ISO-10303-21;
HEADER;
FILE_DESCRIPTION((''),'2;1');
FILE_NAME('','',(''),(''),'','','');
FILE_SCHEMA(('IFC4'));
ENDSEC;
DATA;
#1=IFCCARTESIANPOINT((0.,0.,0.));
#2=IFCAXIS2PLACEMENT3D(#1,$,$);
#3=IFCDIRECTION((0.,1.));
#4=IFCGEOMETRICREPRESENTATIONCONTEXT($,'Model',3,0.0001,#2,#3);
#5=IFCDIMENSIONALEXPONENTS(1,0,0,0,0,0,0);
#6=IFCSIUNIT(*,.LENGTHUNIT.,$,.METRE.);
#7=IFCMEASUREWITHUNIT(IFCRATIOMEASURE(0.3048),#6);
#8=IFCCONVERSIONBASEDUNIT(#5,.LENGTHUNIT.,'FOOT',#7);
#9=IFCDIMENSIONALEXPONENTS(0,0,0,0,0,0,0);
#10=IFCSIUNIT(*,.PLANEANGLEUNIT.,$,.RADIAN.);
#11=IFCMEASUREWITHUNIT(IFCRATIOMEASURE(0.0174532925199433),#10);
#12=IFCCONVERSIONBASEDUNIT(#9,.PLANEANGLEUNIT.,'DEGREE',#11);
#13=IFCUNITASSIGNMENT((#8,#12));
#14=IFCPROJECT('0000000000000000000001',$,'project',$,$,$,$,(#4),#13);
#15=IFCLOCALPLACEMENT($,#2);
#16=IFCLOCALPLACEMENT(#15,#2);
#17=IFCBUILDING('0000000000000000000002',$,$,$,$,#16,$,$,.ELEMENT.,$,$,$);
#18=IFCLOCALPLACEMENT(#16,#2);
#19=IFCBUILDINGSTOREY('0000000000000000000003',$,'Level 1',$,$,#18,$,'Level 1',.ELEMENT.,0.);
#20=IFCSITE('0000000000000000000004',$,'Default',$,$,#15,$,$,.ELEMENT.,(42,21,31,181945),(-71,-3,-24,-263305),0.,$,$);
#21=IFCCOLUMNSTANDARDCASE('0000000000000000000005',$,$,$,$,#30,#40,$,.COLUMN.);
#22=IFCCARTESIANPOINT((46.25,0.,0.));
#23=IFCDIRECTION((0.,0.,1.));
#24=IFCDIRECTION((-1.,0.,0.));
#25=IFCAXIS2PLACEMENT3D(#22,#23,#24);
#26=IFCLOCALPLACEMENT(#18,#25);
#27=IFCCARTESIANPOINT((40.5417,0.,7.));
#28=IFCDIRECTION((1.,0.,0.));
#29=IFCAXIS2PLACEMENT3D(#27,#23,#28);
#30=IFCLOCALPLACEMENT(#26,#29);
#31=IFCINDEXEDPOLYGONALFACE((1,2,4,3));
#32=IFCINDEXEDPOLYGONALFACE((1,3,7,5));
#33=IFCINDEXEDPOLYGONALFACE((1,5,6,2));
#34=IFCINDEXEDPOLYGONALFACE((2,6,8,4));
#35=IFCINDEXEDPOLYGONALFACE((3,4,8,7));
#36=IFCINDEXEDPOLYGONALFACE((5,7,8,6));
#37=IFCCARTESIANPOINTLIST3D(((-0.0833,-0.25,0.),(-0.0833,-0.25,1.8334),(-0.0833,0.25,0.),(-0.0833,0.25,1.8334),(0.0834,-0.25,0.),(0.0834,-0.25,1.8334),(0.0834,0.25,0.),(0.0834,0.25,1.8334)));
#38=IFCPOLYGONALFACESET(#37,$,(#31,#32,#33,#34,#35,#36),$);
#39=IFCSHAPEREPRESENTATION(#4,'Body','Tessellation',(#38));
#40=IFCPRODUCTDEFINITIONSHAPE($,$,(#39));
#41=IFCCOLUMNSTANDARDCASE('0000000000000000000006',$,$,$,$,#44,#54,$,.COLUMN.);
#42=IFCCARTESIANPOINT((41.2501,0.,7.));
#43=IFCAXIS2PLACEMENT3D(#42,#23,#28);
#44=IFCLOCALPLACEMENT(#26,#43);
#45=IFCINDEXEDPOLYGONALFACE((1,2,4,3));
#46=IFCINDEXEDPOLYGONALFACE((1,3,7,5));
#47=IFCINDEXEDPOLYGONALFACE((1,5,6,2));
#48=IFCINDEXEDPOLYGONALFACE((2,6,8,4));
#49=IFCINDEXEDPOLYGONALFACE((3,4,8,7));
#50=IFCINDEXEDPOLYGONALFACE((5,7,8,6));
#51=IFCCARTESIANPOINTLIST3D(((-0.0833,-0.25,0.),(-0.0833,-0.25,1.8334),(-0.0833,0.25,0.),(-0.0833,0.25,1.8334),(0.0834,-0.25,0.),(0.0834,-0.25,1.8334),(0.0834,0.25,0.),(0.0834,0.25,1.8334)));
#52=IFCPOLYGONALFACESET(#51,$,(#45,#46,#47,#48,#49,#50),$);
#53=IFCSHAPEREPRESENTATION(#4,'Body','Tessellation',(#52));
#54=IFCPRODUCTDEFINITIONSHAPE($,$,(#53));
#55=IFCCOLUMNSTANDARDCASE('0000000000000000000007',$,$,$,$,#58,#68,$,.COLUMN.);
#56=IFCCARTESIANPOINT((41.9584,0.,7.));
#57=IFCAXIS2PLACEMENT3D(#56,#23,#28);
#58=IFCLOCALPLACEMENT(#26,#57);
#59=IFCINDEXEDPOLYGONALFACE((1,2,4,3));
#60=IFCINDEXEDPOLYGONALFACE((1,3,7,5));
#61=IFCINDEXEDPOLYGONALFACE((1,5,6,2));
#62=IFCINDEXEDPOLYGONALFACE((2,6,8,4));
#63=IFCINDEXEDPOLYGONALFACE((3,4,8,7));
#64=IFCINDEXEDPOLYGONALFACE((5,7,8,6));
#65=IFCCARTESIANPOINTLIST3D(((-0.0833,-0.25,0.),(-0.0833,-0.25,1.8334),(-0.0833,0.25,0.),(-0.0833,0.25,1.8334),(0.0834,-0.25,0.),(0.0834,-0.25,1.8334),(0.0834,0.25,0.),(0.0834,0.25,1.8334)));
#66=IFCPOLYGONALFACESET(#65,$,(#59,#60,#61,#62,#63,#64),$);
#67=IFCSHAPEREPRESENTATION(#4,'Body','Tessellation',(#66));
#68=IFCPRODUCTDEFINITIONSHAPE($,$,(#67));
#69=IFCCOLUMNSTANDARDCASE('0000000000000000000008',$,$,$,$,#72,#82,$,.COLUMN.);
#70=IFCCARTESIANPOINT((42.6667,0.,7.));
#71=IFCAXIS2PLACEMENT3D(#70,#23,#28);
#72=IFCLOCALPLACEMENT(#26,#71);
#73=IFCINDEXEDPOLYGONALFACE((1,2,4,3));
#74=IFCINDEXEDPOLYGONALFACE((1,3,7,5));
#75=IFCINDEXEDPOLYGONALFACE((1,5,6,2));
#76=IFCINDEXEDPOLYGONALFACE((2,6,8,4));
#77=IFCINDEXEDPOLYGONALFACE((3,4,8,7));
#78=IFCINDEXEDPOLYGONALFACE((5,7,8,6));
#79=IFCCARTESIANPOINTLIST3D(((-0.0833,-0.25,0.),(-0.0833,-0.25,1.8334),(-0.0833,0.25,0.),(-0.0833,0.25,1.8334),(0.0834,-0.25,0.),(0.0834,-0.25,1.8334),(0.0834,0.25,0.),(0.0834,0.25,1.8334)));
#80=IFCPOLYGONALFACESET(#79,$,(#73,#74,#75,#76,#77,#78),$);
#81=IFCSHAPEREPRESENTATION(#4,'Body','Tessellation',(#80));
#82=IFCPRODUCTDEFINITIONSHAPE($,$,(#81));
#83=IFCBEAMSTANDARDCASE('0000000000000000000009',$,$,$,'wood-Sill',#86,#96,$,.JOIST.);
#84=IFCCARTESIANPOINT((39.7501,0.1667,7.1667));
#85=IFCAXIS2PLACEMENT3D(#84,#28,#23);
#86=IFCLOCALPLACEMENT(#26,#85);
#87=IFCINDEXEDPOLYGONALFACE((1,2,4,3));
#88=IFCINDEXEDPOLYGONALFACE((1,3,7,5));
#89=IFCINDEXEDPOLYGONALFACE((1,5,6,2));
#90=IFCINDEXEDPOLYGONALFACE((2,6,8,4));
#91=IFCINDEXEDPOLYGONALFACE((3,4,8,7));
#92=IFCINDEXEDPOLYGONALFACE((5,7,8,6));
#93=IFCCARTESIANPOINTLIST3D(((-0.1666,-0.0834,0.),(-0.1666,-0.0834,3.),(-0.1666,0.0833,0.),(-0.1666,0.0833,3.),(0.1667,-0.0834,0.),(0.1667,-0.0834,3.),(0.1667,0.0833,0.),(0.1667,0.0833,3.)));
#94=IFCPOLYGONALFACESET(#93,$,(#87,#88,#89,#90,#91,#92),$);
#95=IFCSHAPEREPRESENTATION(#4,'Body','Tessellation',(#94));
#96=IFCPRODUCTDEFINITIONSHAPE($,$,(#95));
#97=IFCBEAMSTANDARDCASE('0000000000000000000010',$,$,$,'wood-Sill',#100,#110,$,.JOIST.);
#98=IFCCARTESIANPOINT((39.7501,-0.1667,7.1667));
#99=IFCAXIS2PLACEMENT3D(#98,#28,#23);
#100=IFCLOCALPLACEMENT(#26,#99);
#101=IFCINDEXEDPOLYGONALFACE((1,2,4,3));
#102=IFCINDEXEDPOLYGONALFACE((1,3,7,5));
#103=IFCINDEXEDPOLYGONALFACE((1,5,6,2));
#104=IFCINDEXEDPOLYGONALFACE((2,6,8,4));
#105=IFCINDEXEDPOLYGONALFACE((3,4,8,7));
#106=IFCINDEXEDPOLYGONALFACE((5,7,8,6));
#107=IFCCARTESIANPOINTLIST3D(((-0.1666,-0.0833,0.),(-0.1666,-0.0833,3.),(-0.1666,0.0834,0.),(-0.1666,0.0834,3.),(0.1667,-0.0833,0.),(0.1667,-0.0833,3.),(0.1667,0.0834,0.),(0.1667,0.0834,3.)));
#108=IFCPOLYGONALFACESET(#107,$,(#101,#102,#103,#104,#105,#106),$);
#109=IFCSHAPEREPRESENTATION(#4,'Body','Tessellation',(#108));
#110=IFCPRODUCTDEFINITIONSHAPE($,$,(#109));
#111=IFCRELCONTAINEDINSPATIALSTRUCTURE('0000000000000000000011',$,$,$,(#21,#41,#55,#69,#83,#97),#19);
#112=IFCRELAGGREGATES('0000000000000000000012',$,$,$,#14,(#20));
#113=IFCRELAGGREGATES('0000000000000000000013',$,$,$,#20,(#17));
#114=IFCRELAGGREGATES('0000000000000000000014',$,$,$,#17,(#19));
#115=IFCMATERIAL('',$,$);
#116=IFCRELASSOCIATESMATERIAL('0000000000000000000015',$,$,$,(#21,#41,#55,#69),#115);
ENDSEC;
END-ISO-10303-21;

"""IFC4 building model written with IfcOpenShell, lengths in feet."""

from ifc_helpers import new_model, entity, si_unit, converted_unit, direction, frame, origin, origin_with_axes, place, context, project, spatial, rectangle, extrude, material, element, save


model = new_model("IFC4")

# Units and contexts
model_context = context("Model", 3, precision=0.0001, world=origin(), true_north=direction((0.0, 1.0)))
ifc_project = project(units=[converted_unit("LENGTHUNIT", "FOOT", entity("IfcRatioMeasure", 0.3048), si_unit("LENGTHUNIT", "METRE"), dimensions=[1, 0, 0, 0, 0, 0, 0]), converted_unit("PLANEANGLEUNIT", "DEGREE", entity("IfcRatioMeasure", 0.0174532925199433), si_unit("PLANEANGLEUNIT", "RADIAN"), dimensions=[0, 0, 0, 0, 0, 0, 0])], contexts=[model_context])

# Site, building, storey
site_placement = place(None, origin())
site = spatial("IfcSite", under=ifc_project, at=site_placement, Name="Default", CompositionType="ELEMENT", RefLatitude=(42, 21, 31, 181945), RefLongitude=(-71, -3, -24, -263305), RefElevation=0.0)
building_placement = place(site_placement, origin())
building = spatial("IfcBuilding", under=site, at=building_placement, CompositionType="ELEMENT")
storey_placement = place(building_placement, origin())
storey = spatial("IfcBuildingStorey", under=building, at=storey_placement, Name="Level 1", LongName="Level 1", CompositionType="ELEMENT", Elevation=0.0)

# Columns
placement_1 = place(storey_placement, frame((46.25, 0.0, 0.0), z_axis=(0.0, 0.0, 1.0), x_axis=(-1.0, 0.0, 0.0)))
ifc_material_1 = material(Name="")
for number, where, z_axis, x_axis in (
    (1, (40.5417, 0.0, 7.0), (0.0, 0.0, 1.0), (1.0, 0.0, 0.0)),
    (2, (41.2501, 0.0, 7.0), (0.0, 0.0, 1.0), (1.0, 0.0, 0.0)),
    (3, (41.9584, 0.0, 7.0), (0.0, 0.0, 1.0), (1.0, 0.0, 0.0)),
    (4, (42.6667, 0.0, 7.0), (0.0, 0.0, 1.0), (1.0, 0.0, 0.0)),
):
    element("IfcColumnStandardCase", number, at=place(placement_1, frame(where, z_axis=z_axis, x_axis=x_axis)), inside=storey, material=ifc_material_1, PredefinedType="COLUMN", context=model_context, shape_type="SweptSolid", body=[
        extrude(rectangle(XDim=0.1667, YDim=0.5), origin(), (0.0, 0.0, 1.0), 1.8334),
    ])

# Beams
for number, where, z_axis, x_axis in (
    (5, (39.7501, 0.1667, 7.1667), (1.0, 0.0, 0.0), (0.0, 0.0, 1.0)),
    (6, (39.7501, -0.1667, 7.1667), (1.0, 0.0, 0.0), (0.0, 0.0, 1.0)),
):
    element("IfcBeamStandardCase", number, at=place(placement_1, frame(where, z_axis=z_axis, x_axis=x_axis)), inside=storey, ObjectType="wood-Sill", PredefinedType="JOIST", context=model_context, shape_type="SweptSolid", body=[
        extrude(rectangle(XDim=0.3333, YDim=0.1667), origin_with_axes(), (0.0, 0.0, 1.0), 3.0),
    ])

save(model, "model.ifc")
